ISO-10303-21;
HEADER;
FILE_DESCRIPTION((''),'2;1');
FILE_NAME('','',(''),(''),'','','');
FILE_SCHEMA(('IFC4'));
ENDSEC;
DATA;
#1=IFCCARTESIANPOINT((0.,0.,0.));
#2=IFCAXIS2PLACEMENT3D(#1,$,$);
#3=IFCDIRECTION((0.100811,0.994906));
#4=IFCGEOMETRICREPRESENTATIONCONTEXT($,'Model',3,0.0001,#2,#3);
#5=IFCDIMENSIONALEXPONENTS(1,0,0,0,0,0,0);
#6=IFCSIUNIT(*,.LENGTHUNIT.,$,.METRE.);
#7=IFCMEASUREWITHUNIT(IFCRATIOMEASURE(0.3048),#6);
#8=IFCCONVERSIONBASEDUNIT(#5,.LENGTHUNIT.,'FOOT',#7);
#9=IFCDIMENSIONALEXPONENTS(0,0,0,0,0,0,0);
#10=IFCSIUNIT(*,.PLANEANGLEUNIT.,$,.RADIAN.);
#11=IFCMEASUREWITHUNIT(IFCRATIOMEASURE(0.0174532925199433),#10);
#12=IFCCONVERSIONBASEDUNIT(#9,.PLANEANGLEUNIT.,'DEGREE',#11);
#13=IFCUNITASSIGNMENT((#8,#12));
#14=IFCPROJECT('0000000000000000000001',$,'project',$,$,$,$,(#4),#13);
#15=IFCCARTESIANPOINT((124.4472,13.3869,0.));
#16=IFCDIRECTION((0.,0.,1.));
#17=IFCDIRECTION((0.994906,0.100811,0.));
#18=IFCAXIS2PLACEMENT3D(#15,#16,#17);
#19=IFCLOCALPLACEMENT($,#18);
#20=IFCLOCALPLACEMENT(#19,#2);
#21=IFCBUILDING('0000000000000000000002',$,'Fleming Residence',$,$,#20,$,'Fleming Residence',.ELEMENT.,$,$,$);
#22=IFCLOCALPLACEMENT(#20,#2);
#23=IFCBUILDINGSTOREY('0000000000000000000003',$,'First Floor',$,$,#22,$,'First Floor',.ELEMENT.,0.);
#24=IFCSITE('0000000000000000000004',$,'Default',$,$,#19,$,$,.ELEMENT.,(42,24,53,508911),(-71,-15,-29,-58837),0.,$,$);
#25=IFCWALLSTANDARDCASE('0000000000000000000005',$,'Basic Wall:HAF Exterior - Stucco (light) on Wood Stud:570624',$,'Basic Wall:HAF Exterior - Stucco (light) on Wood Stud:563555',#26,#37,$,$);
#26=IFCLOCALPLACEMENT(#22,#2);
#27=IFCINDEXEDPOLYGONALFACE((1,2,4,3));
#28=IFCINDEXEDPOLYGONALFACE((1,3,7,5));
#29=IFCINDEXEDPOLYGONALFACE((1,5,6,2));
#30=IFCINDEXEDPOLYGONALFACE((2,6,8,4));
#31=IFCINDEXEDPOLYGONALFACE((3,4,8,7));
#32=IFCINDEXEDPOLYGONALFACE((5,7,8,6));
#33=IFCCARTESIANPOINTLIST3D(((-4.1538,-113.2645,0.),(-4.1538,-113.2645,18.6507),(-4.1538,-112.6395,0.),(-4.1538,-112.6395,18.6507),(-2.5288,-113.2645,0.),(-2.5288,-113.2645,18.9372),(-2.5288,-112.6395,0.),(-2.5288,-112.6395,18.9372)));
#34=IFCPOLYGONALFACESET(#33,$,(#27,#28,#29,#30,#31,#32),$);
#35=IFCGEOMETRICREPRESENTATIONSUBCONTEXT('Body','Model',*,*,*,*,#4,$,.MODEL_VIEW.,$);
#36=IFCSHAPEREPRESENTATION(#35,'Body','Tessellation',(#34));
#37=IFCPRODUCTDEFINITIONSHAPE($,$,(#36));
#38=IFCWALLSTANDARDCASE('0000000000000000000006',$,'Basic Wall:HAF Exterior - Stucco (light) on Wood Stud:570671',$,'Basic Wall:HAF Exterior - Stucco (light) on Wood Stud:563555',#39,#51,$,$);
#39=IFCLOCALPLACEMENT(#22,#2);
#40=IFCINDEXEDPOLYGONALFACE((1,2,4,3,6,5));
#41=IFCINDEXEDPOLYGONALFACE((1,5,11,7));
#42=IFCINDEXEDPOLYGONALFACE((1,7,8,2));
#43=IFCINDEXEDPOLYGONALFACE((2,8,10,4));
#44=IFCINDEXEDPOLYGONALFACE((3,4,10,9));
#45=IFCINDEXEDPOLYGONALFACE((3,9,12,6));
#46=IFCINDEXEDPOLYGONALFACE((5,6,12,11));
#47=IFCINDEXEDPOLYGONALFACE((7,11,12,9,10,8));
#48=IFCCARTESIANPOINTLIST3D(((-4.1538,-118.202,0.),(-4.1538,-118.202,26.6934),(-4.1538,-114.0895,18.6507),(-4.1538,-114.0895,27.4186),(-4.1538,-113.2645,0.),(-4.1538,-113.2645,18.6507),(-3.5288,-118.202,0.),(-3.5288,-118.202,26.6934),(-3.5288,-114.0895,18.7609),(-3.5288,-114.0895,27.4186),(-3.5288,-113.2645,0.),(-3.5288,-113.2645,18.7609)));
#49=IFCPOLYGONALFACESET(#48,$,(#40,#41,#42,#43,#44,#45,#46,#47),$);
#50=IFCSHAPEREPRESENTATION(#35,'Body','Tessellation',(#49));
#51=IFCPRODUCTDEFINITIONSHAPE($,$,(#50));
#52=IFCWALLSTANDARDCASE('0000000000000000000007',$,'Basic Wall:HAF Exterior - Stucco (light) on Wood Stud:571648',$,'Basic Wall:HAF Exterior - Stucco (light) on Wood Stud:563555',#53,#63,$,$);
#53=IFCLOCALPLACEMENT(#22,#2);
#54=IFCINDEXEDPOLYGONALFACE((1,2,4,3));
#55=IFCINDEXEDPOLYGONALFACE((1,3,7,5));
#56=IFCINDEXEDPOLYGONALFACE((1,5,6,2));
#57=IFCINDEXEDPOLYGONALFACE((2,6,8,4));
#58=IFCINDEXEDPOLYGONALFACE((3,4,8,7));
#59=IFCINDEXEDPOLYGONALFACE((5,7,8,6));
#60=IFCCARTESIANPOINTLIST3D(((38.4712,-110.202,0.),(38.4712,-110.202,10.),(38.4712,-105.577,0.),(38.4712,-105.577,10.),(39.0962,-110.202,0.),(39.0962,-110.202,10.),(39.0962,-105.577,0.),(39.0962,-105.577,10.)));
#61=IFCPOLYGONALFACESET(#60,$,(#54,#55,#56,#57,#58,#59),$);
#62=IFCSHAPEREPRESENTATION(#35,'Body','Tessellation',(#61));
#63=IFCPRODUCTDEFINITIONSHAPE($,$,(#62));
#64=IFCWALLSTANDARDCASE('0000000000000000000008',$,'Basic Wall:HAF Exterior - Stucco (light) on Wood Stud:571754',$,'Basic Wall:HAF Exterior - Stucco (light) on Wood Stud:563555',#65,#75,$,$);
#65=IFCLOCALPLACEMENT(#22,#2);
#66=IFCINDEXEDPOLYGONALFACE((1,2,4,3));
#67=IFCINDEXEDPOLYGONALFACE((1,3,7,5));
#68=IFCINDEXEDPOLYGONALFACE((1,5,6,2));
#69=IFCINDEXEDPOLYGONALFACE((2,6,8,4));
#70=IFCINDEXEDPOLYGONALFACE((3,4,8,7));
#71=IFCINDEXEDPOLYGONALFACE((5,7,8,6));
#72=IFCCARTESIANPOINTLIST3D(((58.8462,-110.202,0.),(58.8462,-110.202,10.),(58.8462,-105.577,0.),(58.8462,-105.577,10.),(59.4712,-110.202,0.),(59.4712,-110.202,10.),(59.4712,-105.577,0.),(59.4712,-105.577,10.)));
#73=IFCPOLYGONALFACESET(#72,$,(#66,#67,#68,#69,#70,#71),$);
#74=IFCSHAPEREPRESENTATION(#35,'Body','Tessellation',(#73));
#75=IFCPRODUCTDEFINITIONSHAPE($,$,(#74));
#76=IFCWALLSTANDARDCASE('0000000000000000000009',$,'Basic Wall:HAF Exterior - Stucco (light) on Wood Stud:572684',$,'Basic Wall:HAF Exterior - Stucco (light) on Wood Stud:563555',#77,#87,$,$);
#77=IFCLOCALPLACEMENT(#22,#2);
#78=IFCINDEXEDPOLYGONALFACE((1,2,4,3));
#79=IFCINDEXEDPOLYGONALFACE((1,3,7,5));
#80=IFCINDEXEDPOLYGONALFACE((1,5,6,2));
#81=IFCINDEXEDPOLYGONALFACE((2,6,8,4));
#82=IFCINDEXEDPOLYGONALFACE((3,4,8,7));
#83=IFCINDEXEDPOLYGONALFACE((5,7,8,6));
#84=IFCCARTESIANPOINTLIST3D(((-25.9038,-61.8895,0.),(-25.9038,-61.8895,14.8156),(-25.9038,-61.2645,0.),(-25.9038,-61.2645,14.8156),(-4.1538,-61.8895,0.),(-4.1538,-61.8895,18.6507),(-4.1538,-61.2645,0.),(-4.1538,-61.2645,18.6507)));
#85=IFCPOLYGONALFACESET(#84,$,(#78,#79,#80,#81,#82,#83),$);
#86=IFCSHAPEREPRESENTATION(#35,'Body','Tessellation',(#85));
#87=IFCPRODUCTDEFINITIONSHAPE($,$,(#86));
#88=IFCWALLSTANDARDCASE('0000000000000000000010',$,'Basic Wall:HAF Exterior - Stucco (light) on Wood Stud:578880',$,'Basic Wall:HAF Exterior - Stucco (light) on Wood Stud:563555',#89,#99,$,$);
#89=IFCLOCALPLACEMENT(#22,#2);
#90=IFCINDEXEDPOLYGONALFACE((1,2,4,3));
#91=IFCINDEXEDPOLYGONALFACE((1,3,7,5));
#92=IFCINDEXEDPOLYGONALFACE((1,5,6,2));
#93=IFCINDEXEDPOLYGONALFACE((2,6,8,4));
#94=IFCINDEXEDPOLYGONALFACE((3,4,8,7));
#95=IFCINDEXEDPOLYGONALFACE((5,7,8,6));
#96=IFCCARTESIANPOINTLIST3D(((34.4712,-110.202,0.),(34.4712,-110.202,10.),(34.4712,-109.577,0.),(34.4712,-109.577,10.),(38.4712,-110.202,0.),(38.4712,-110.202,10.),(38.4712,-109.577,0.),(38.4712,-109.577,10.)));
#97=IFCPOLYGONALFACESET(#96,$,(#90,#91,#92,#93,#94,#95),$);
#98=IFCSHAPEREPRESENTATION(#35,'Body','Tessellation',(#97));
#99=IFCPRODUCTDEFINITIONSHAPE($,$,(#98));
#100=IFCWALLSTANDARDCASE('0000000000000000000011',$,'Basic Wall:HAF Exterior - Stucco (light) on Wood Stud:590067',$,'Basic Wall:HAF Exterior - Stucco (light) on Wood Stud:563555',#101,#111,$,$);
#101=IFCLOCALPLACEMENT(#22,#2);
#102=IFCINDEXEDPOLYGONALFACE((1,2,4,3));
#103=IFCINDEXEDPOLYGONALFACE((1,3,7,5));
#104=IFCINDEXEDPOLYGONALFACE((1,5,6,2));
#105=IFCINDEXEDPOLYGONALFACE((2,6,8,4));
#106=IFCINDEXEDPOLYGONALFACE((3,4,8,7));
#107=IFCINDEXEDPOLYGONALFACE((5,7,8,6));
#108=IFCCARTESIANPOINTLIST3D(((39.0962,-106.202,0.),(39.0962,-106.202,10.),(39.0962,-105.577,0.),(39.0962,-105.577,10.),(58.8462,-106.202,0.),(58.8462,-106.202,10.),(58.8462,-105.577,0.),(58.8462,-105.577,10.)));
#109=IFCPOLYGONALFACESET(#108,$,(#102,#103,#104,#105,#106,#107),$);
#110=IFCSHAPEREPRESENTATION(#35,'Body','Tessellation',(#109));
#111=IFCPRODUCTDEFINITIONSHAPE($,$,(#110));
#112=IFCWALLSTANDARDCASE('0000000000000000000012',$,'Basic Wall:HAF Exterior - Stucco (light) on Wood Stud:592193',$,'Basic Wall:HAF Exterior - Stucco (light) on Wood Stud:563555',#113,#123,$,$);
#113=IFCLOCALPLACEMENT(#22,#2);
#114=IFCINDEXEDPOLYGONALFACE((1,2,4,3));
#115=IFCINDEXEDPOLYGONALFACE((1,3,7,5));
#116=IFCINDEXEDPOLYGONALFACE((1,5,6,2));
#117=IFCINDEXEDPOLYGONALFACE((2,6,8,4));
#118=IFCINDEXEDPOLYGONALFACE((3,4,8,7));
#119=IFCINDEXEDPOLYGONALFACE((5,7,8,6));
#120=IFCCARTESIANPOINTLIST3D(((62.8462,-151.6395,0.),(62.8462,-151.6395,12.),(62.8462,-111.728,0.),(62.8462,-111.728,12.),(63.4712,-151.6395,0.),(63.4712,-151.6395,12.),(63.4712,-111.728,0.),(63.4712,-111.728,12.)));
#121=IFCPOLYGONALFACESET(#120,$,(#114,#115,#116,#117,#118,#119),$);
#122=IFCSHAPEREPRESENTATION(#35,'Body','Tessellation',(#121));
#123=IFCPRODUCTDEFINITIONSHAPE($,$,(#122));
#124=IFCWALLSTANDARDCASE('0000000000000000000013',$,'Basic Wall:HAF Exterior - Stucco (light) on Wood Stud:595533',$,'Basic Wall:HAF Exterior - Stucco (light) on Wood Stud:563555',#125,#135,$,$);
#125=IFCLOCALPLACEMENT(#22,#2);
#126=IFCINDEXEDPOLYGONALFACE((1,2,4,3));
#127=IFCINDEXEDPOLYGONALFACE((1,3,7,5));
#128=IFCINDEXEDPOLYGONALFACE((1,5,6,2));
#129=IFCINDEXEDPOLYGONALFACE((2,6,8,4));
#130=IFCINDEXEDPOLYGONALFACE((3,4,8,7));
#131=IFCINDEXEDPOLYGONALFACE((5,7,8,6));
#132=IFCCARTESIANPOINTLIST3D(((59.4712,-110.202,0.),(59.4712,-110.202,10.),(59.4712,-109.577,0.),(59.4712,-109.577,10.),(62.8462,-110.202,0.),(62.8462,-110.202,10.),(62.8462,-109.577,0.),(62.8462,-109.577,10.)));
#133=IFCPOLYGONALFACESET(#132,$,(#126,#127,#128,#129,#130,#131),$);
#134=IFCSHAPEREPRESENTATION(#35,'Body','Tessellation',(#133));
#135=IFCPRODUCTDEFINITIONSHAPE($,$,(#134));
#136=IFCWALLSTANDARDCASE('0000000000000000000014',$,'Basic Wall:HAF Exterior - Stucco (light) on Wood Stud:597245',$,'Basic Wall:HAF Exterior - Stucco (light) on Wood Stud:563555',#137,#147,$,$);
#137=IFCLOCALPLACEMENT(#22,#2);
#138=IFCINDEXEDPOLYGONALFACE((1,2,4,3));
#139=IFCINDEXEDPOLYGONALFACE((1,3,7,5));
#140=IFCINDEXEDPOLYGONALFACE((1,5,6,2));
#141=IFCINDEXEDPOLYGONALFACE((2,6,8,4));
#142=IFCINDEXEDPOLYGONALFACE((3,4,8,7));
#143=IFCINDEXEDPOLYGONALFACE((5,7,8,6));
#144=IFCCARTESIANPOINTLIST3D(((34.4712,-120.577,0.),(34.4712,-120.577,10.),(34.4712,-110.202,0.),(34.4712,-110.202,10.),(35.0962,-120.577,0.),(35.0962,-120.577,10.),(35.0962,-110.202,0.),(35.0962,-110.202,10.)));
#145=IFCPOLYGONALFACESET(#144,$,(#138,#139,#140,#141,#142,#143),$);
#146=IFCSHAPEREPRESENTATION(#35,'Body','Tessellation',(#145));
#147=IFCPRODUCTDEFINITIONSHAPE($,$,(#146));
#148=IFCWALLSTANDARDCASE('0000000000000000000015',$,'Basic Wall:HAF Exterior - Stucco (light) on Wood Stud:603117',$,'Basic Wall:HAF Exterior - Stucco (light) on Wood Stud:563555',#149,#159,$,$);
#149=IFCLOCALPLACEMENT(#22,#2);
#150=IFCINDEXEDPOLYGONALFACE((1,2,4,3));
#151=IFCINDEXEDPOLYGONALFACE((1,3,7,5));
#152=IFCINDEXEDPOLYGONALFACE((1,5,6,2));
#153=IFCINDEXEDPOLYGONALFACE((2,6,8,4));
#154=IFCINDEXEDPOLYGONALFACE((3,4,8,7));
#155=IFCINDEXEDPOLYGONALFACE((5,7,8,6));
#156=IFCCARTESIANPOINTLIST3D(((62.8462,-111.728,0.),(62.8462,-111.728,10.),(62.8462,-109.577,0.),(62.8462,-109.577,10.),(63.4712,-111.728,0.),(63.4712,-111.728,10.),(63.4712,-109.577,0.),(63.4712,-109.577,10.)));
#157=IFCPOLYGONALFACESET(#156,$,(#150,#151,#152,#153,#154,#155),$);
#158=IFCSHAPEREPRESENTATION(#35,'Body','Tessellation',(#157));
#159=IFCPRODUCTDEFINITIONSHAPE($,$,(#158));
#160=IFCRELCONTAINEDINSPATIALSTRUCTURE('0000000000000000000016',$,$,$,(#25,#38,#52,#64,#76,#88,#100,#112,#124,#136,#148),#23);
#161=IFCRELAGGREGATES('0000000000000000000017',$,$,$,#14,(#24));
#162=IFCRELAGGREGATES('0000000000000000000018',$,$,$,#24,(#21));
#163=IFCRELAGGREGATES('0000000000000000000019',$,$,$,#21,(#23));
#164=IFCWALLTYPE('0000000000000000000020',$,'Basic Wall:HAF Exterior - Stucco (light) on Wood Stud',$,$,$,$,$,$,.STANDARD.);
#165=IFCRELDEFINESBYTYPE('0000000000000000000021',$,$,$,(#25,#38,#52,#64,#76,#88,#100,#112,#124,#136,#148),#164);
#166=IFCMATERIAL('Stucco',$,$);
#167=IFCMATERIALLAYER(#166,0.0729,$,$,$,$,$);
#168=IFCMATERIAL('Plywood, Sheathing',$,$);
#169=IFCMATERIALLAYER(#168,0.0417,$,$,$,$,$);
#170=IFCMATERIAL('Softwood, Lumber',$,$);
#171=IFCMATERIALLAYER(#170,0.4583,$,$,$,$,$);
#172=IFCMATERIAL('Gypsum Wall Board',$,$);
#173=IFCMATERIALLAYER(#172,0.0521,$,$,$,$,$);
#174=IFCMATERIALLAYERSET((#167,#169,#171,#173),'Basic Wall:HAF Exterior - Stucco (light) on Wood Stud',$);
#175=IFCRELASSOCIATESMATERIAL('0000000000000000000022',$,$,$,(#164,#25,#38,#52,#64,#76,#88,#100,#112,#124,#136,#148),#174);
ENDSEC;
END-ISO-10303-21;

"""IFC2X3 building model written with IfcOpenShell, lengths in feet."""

from ifc_helpers import new_model, entity, si_unit, converted_unit, direction, frame, frame_2d, origin, place, context, subcontext, project, spatial, polyline, rectangle, extrude, clip, bounded_halfspace, material, layer, layer_set, layer_usage, type_object, element, save


model = new_model("IFC2X3")

# Units and contexts
model_context = context("Model", 3, precision=0.0001, world=origin(), true_north=direction((0.100811, 0.994906)))
body_context = subcontext(model_context, "Body", "Model", "MODEL_VIEW")
ifc_project = project(units=[converted_unit("LENGTHUNIT", "FOOT", entity("IfcRatioMeasure", 0.3048), si_unit("LENGTHUNIT", "METRE"), dimensions=[1, 0, 0, 0, 0, 0, 0]), converted_unit("PLANEANGLEUNIT", "DEGREE", entity("IfcRatioMeasure", 0.0174532925199433), si_unit("PLANEANGLEUNIT", "RADIAN"), dimensions=[0, 0, 0, 0, 0, 0, 0])], contexts=[model_context])

# Site, building, storey
site_placement = place(None, frame((124.4472, 13.3869, 0.0), z_axis=(0.0, 0.0, 1.0), x_axis=(0.994906, 0.100811, 0.0)))
site = spatial("IfcSite", under=ifc_project, at=site_placement, Name="Default", CompositionType="ELEMENT", RefLatitude=(42, 24, 53, 508911), RefLongitude=(-71, -15, -29, -58837), RefElevation=0.0)
building_placement = place(site_placement, origin())
building = spatial("IfcBuilding", under=site, at=building_placement, Name="Fleming Residence", LongName="Fleming Residence", CompositionType="ELEMENT")
storey_placement = place(building_placement, origin())
storey = spatial("IfcBuildingStorey", under=building, at=storey_placement, Name="First Floor", LongName="First Floor", CompositionType="ELEMENT", Elevation=0.0)

# Walls
ifc_material_1 = material(Name="Stucco")
ifc_layer_1 = layer(ifc_material_1, 0.0729)
ifc_material_2 = material(Name="Plywood, Sheathing")
ifc_layer_2 = layer(ifc_material_2, 0.0417)
ifc_material_3 = material(Name="Softwood, Lumber")
ifc_layer_3 = layer(ifc_material_3, 0.4583)
ifc_material_4 = material(Name="Gypsum Wall Board")
ifc_layer_4 = layer(ifc_material_4, 0.0521)
ifc_layer_set_1 = layer_set([ifc_layer_1, ifc_layer_2, ifc_layer_3, ifc_layer_4], Name="Basic Wall:HAF Exterior - Stucco (light) on Wood Stud")
wall_type_1 = type_object("IfcWallType", Name="Basic Wall:HAF Exterior - Stucco (light) on Wood Stud", PredefinedType="STANDARD", material=ifc_layer_set_1)
ifc_layer_usage_1 = layer_usage(ifc_layer_set_1, "AXIS2", "NEGATIVE", 0.3125)
wall_1_placement = place(storey_placement, frame((-2.5288, -112.952, 0.0), z_axis=(0.0, 0.0, 1.0), x_axis=(-1.0, 0.0, 0.0)))
element("IfcWallStandardCase", 1, at=wall_1_placement, inside=storey, type_object=wall_type_1, material=ifc_layer_usage_1, Name="Basic Wall:HAF Exterior - Stucco (light) on Wood Stud:570624", ObjectType="Basic Wall:HAF Exterior - Stucco (light) on Wood Stud:563555", context=body_context, shape_type="Clipping", body=[
    clip(extrude(rectangle(XDim=1.625, YDim=0.625, at=frame_2d((0.8125, 0.0), x_axis=(-1.0, 0.0))), origin(), (0.0, 0.0, 1.0), 18.9372), bounded_halfspace(frame((0.0, -0.3125, 18.9372), z_axis=(-0.173648, 0.0, -0.984808), x_axis=(0.0, 1.0, 0.0)), True, frame((0.0, -0.3125, 18.9372)), polyline([(0.0, 0.0), (0.625, 0.0), (1.625, 0.0), (1.625, 0.625), (1.0, 0.625), (0.0, 0.625), (0.0, 0.0)]))),
])
ifc_layer_usage_2 = layer_usage(ifc_layer_set_1, "AXIS2", "NEGATIVE", 0.3125)
wall_2_placement = place(storey_placement, frame((-3.8413, -113.2645, 0.0), z_axis=(0.0, 0.0, 1.0), x_axis=(0.0, -1.0, 0.0)))
element("IfcWallStandardCase", 2, at=wall_2_placement, inside=storey, type_object=wall_type_1, material=ifc_layer_usage_2, Name="Basic Wall:HAF Exterior - Stucco (light) on Wood Stud:570671", ObjectType="Basic Wall:HAF Exterior - Stucco (light) on Wood Stud:563555", context=body_context, shape_type="Clipping", body=[
    clip(clip(extrude(rectangle(XDim=4.9375, YDim=0.625, at=frame_2d((2.4688, 0.0), x_axis=(-1.0, 0.0))), origin(), (0.0, 0.0, 1.0), 27.4186), bounded_halfspace(frame((0.0, -0.3125, 18.6507), z_axis=(0.0, 0.173648, -0.984808), x_axis=(1.0, 0.0, 0.0)), True, frame((0.0, -0.3125, 18.6507)), polyline([(0.0, 0.0), (0.825, 0.0), (0.825, 0.625), (0.0, 0.625), (0.0, 0.0)]))), bounded_halfspace(frame((0.825, -0.3125, 27.4186), z_axis=(-0.173648, 0.0, -0.984808), x_axis=(0.0, -1.0, 0.0)), True, frame((0.825, -0.3125, 27.4186)), polyline([(0.0, 0.0), (0.0604, 0.0), (4.1125, 0.0), (4.1125, 0.625), (3.4875, 0.625), (0.0, 0.625), (0.0, 0.0)]))),
])
ifc_layer_usage_3 = layer_usage(ifc_layer_set_1, "AXIS2", "NEGATIVE", 0.3125)
wall_3_placement = place(storey_placement, frame((38.7837, -110.202, 0.0), z_axis=(0.0, 0.0, 1.0), x_axis=(0.0, 1.0, 0.0)))
element("IfcWallStandardCase", 3, at=wall_3_placement, inside=storey, type_object=wall_type_1, material=ifc_layer_usage_3, Name="Basic Wall:HAF Exterior - Stucco (light) on Wood Stud:571648", ObjectType="Basic Wall:HAF Exterior - Stucco (light) on Wood Stud:563555", context=body_context, shape_type="SweptSolid", body=[
    extrude(rectangle(XDim=4.625, YDim=0.625, at=frame_2d((2.3125, 0.0), x_axis=(-1.0, 0.0))), origin(), (0.0, 0.0, 1.0), 10.0),
])
ifc_layer_usage_4 = layer_usage(ifc_layer_set_1, "AXIS2", "NEGATIVE", 0.3125)
wall_4_placement = place(storey_placement, frame((59.1587, -105.577, 0.0), z_axis=(0.0, 0.0, 1.0), x_axis=(0.0, -1.0, 0.0)))
element("IfcWallStandardCase", 4, at=wall_4_placement, inside=storey, type_object=wall_type_1, material=ifc_layer_usage_4, Name="Basic Wall:HAF Exterior - Stucco (light) on Wood Stud:571754", ObjectType="Basic Wall:HAF Exterior - Stucco (light) on Wood Stud:563555", context=body_context, shape_type="SweptSolid", body=[
    extrude(rectangle(XDim=4.625, YDim=0.625, at=frame_2d((2.3125, 0.0), x_axis=(-1.0, 0.0))), origin(), (0.0, 0.0, 1.0), 10.0),
])
ifc_layer_usage_5 = layer_usage(ifc_layer_set_1, "AXIS2", "NEGATIVE", 0.3125)
wall_5_placement = place(storey_placement, frame((-25.9038, -61.577, 0.0)))
element("IfcWallStandardCase", 5, at=wall_5_placement, inside=storey, type_object=wall_type_1, material=ifc_layer_usage_5, Name="Basic Wall:HAF Exterior - Stucco (light) on Wood Stud:572684", ObjectType="Basic Wall:HAF Exterior - Stucco (light) on Wood Stud:563555", context=body_context, shape_type="Clipping", body=[
    clip(extrude(rectangle(XDim=21.75, YDim=0.625, at=frame_2d((10.875, 0.0), x_axis=(-1.0, 0.0))), origin(), (0.0, 0.0, 1.0), 18.6507), bounded_halfspace(frame((0.0, -0.3125, 14.8156), z_axis=(0.173648, 0.0, -0.984808), x_axis=(0.0, -1.0, 0.0)), True, frame((0.0, -0.3125, 14.8156)), polyline([(0.0, 0.0), (21.75, 0.0), (21.75, 0.625), (0.0, 0.625), (0.0, 0.0)]))),
])
ifc_layer_usage_6 = layer_usage(ifc_layer_set_1, "AXIS2", "NEGATIVE", 0.3125)
wall_6_placement = place(storey_placement, frame((34.4712, -109.8895, 0.0)))
element("IfcWallStandardCase", 6, at=wall_6_placement, inside=storey, type_object=wall_type_1, material=ifc_layer_usage_6, Name="Basic Wall:HAF Exterior - Stucco (light) on Wood Stud:578880", ObjectType="Basic Wall:HAF Exterior - Stucco (light) on Wood Stud:563555", context=body_context, shape_type="SweptSolid", body=[
    extrude(rectangle(XDim=4.0, YDim=0.625, at=frame_2d((2.0, 0.0), x_axis=(-1.0, 0.0))), origin(), (0.0, 0.0, 1.0), 10.0),
])
ifc_layer_usage_7 = layer_usage(ifc_layer_set_1, "AXIS2", "NEGATIVE", 0.3125)
wall_7_placement = place(storey_placement, frame((39.0962, -105.8895, 0.0)))
element("IfcWallStandardCase", 7, at=wall_7_placement, inside=storey, type_object=wall_type_1, material=ifc_layer_usage_7, Name="Basic Wall:HAF Exterior - Stucco (light) on Wood Stud:590067", ObjectType="Basic Wall:HAF Exterior - Stucco (light) on Wood Stud:563555", context=body_context, shape_type="SweptSolid", body=[
    extrude(rectangle(XDim=19.75, YDim=0.625, at=frame_2d((9.875, 0.0), x_axis=(-1.0, 0.0))), origin(), (0.0, 0.0, 1.0), 10.0),
])
ifc_layer_usage_8 = layer_usage(ifc_layer_set_1, "AXIS2", "NEGATIVE", 0.3125)
wall_8_placement = place(storey_placement, frame((63.1587, -111.728, 0.0), z_axis=(0.0, 0.0, 1.0), x_axis=(0.0, -1.0, 0.0)))
element("IfcWallStandardCase", 8, at=wall_8_placement, inside=storey, type_object=wall_type_1, material=ifc_layer_usage_8, Name="Basic Wall:HAF Exterior - Stucco (light) on Wood Stud:592193", ObjectType="Basic Wall:HAF Exterior - Stucco (light) on Wood Stud:563555", context=body_context, shape_type="SweptSolid", body=[
    extrude(rectangle(XDim=39.9115, YDim=0.625, at=frame_2d((19.9557, 0.0), x_axis=(-1.0, 0.0))), origin(), (0.0, 0.0, 1.0), 12.0),
])
ifc_layer_usage_9 = layer_usage(ifc_layer_set_1, "AXIS2", "NEGATIVE", 0.3125)
wall_9_placement = place(storey_placement, frame((59.4712, -109.8895, 0.0)))
element("IfcWallStandardCase", 9, at=wall_9_placement, inside=storey, type_object=wall_type_1, material=ifc_layer_usage_9, Name="Basic Wall:HAF Exterior - Stucco (light) on Wood Stud:595533", ObjectType="Basic Wall:HAF Exterior - Stucco (light) on Wood Stud:563555", context=body_context, shape_type="SweptSolid", body=[
    extrude(rectangle(XDim=3.375, YDim=0.625, at=frame_2d((1.6875, 0.0), x_axis=(-1.0, 0.0))), origin(), (0.0, 0.0, 1.0), 10.0),
])
ifc_layer_usage_10 = layer_usage(ifc_layer_set_1, "AXIS2", "POSITIVE", -0.3125)
wall_10_placement = place(storey_placement, frame((34.7837, -110.202, 0.0), z_axis=(0.0, 0.0, 1.0), x_axis=(0.0, -1.0, 0.0)))
element("IfcWallStandardCase", 10, at=wall_10_placement, inside=storey, type_object=wall_type_1, material=ifc_layer_usage_10, Name="Basic Wall:HAF Exterior - Stucco (light) on Wood Stud:597245", ObjectType="Basic Wall:HAF Exterior - Stucco (light) on Wood Stud:563555", context=body_context, shape_type="SweptSolid", body=[
    extrude(rectangle(XDim=10.375, YDim=0.625, at=frame_2d((5.1875, 0.0), x_axis=(-1.0, 0.0))), origin(), (0.0, 0.0, 1.0), 10.0),
])
ifc_layer_usage_11 = layer_usage(ifc_layer_set_1, "AXIS2", "NEGATIVE", 0.3125)
wall_11_placement = place(storey_placement, frame((63.1587, -109.577, 0.0), z_axis=(0.0, 0.0, 1.0), x_axis=(0.0, -1.0, 0.0)))
element("IfcWallStandardCase", 11, at=wall_11_placement, inside=storey, type_object=wall_type_1, material=ifc_layer_usage_11, Name="Basic Wall:HAF Exterior - Stucco (light) on Wood Stud:603117", ObjectType="Basic Wall:HAF Exterior - Stucco (light) on Wood Stud:563555", context=body_context, shape_type="SweptSolid", body=[
    extrude(rectangle(XDim=2.151, YDim=0.625, at=frame_2d((1.0755, 0.0), x_axis=(-1.0, 0.0))), origin(), (0.0, 0.0, 1.0), 10.0),
])

save(model, "model.ifc")
